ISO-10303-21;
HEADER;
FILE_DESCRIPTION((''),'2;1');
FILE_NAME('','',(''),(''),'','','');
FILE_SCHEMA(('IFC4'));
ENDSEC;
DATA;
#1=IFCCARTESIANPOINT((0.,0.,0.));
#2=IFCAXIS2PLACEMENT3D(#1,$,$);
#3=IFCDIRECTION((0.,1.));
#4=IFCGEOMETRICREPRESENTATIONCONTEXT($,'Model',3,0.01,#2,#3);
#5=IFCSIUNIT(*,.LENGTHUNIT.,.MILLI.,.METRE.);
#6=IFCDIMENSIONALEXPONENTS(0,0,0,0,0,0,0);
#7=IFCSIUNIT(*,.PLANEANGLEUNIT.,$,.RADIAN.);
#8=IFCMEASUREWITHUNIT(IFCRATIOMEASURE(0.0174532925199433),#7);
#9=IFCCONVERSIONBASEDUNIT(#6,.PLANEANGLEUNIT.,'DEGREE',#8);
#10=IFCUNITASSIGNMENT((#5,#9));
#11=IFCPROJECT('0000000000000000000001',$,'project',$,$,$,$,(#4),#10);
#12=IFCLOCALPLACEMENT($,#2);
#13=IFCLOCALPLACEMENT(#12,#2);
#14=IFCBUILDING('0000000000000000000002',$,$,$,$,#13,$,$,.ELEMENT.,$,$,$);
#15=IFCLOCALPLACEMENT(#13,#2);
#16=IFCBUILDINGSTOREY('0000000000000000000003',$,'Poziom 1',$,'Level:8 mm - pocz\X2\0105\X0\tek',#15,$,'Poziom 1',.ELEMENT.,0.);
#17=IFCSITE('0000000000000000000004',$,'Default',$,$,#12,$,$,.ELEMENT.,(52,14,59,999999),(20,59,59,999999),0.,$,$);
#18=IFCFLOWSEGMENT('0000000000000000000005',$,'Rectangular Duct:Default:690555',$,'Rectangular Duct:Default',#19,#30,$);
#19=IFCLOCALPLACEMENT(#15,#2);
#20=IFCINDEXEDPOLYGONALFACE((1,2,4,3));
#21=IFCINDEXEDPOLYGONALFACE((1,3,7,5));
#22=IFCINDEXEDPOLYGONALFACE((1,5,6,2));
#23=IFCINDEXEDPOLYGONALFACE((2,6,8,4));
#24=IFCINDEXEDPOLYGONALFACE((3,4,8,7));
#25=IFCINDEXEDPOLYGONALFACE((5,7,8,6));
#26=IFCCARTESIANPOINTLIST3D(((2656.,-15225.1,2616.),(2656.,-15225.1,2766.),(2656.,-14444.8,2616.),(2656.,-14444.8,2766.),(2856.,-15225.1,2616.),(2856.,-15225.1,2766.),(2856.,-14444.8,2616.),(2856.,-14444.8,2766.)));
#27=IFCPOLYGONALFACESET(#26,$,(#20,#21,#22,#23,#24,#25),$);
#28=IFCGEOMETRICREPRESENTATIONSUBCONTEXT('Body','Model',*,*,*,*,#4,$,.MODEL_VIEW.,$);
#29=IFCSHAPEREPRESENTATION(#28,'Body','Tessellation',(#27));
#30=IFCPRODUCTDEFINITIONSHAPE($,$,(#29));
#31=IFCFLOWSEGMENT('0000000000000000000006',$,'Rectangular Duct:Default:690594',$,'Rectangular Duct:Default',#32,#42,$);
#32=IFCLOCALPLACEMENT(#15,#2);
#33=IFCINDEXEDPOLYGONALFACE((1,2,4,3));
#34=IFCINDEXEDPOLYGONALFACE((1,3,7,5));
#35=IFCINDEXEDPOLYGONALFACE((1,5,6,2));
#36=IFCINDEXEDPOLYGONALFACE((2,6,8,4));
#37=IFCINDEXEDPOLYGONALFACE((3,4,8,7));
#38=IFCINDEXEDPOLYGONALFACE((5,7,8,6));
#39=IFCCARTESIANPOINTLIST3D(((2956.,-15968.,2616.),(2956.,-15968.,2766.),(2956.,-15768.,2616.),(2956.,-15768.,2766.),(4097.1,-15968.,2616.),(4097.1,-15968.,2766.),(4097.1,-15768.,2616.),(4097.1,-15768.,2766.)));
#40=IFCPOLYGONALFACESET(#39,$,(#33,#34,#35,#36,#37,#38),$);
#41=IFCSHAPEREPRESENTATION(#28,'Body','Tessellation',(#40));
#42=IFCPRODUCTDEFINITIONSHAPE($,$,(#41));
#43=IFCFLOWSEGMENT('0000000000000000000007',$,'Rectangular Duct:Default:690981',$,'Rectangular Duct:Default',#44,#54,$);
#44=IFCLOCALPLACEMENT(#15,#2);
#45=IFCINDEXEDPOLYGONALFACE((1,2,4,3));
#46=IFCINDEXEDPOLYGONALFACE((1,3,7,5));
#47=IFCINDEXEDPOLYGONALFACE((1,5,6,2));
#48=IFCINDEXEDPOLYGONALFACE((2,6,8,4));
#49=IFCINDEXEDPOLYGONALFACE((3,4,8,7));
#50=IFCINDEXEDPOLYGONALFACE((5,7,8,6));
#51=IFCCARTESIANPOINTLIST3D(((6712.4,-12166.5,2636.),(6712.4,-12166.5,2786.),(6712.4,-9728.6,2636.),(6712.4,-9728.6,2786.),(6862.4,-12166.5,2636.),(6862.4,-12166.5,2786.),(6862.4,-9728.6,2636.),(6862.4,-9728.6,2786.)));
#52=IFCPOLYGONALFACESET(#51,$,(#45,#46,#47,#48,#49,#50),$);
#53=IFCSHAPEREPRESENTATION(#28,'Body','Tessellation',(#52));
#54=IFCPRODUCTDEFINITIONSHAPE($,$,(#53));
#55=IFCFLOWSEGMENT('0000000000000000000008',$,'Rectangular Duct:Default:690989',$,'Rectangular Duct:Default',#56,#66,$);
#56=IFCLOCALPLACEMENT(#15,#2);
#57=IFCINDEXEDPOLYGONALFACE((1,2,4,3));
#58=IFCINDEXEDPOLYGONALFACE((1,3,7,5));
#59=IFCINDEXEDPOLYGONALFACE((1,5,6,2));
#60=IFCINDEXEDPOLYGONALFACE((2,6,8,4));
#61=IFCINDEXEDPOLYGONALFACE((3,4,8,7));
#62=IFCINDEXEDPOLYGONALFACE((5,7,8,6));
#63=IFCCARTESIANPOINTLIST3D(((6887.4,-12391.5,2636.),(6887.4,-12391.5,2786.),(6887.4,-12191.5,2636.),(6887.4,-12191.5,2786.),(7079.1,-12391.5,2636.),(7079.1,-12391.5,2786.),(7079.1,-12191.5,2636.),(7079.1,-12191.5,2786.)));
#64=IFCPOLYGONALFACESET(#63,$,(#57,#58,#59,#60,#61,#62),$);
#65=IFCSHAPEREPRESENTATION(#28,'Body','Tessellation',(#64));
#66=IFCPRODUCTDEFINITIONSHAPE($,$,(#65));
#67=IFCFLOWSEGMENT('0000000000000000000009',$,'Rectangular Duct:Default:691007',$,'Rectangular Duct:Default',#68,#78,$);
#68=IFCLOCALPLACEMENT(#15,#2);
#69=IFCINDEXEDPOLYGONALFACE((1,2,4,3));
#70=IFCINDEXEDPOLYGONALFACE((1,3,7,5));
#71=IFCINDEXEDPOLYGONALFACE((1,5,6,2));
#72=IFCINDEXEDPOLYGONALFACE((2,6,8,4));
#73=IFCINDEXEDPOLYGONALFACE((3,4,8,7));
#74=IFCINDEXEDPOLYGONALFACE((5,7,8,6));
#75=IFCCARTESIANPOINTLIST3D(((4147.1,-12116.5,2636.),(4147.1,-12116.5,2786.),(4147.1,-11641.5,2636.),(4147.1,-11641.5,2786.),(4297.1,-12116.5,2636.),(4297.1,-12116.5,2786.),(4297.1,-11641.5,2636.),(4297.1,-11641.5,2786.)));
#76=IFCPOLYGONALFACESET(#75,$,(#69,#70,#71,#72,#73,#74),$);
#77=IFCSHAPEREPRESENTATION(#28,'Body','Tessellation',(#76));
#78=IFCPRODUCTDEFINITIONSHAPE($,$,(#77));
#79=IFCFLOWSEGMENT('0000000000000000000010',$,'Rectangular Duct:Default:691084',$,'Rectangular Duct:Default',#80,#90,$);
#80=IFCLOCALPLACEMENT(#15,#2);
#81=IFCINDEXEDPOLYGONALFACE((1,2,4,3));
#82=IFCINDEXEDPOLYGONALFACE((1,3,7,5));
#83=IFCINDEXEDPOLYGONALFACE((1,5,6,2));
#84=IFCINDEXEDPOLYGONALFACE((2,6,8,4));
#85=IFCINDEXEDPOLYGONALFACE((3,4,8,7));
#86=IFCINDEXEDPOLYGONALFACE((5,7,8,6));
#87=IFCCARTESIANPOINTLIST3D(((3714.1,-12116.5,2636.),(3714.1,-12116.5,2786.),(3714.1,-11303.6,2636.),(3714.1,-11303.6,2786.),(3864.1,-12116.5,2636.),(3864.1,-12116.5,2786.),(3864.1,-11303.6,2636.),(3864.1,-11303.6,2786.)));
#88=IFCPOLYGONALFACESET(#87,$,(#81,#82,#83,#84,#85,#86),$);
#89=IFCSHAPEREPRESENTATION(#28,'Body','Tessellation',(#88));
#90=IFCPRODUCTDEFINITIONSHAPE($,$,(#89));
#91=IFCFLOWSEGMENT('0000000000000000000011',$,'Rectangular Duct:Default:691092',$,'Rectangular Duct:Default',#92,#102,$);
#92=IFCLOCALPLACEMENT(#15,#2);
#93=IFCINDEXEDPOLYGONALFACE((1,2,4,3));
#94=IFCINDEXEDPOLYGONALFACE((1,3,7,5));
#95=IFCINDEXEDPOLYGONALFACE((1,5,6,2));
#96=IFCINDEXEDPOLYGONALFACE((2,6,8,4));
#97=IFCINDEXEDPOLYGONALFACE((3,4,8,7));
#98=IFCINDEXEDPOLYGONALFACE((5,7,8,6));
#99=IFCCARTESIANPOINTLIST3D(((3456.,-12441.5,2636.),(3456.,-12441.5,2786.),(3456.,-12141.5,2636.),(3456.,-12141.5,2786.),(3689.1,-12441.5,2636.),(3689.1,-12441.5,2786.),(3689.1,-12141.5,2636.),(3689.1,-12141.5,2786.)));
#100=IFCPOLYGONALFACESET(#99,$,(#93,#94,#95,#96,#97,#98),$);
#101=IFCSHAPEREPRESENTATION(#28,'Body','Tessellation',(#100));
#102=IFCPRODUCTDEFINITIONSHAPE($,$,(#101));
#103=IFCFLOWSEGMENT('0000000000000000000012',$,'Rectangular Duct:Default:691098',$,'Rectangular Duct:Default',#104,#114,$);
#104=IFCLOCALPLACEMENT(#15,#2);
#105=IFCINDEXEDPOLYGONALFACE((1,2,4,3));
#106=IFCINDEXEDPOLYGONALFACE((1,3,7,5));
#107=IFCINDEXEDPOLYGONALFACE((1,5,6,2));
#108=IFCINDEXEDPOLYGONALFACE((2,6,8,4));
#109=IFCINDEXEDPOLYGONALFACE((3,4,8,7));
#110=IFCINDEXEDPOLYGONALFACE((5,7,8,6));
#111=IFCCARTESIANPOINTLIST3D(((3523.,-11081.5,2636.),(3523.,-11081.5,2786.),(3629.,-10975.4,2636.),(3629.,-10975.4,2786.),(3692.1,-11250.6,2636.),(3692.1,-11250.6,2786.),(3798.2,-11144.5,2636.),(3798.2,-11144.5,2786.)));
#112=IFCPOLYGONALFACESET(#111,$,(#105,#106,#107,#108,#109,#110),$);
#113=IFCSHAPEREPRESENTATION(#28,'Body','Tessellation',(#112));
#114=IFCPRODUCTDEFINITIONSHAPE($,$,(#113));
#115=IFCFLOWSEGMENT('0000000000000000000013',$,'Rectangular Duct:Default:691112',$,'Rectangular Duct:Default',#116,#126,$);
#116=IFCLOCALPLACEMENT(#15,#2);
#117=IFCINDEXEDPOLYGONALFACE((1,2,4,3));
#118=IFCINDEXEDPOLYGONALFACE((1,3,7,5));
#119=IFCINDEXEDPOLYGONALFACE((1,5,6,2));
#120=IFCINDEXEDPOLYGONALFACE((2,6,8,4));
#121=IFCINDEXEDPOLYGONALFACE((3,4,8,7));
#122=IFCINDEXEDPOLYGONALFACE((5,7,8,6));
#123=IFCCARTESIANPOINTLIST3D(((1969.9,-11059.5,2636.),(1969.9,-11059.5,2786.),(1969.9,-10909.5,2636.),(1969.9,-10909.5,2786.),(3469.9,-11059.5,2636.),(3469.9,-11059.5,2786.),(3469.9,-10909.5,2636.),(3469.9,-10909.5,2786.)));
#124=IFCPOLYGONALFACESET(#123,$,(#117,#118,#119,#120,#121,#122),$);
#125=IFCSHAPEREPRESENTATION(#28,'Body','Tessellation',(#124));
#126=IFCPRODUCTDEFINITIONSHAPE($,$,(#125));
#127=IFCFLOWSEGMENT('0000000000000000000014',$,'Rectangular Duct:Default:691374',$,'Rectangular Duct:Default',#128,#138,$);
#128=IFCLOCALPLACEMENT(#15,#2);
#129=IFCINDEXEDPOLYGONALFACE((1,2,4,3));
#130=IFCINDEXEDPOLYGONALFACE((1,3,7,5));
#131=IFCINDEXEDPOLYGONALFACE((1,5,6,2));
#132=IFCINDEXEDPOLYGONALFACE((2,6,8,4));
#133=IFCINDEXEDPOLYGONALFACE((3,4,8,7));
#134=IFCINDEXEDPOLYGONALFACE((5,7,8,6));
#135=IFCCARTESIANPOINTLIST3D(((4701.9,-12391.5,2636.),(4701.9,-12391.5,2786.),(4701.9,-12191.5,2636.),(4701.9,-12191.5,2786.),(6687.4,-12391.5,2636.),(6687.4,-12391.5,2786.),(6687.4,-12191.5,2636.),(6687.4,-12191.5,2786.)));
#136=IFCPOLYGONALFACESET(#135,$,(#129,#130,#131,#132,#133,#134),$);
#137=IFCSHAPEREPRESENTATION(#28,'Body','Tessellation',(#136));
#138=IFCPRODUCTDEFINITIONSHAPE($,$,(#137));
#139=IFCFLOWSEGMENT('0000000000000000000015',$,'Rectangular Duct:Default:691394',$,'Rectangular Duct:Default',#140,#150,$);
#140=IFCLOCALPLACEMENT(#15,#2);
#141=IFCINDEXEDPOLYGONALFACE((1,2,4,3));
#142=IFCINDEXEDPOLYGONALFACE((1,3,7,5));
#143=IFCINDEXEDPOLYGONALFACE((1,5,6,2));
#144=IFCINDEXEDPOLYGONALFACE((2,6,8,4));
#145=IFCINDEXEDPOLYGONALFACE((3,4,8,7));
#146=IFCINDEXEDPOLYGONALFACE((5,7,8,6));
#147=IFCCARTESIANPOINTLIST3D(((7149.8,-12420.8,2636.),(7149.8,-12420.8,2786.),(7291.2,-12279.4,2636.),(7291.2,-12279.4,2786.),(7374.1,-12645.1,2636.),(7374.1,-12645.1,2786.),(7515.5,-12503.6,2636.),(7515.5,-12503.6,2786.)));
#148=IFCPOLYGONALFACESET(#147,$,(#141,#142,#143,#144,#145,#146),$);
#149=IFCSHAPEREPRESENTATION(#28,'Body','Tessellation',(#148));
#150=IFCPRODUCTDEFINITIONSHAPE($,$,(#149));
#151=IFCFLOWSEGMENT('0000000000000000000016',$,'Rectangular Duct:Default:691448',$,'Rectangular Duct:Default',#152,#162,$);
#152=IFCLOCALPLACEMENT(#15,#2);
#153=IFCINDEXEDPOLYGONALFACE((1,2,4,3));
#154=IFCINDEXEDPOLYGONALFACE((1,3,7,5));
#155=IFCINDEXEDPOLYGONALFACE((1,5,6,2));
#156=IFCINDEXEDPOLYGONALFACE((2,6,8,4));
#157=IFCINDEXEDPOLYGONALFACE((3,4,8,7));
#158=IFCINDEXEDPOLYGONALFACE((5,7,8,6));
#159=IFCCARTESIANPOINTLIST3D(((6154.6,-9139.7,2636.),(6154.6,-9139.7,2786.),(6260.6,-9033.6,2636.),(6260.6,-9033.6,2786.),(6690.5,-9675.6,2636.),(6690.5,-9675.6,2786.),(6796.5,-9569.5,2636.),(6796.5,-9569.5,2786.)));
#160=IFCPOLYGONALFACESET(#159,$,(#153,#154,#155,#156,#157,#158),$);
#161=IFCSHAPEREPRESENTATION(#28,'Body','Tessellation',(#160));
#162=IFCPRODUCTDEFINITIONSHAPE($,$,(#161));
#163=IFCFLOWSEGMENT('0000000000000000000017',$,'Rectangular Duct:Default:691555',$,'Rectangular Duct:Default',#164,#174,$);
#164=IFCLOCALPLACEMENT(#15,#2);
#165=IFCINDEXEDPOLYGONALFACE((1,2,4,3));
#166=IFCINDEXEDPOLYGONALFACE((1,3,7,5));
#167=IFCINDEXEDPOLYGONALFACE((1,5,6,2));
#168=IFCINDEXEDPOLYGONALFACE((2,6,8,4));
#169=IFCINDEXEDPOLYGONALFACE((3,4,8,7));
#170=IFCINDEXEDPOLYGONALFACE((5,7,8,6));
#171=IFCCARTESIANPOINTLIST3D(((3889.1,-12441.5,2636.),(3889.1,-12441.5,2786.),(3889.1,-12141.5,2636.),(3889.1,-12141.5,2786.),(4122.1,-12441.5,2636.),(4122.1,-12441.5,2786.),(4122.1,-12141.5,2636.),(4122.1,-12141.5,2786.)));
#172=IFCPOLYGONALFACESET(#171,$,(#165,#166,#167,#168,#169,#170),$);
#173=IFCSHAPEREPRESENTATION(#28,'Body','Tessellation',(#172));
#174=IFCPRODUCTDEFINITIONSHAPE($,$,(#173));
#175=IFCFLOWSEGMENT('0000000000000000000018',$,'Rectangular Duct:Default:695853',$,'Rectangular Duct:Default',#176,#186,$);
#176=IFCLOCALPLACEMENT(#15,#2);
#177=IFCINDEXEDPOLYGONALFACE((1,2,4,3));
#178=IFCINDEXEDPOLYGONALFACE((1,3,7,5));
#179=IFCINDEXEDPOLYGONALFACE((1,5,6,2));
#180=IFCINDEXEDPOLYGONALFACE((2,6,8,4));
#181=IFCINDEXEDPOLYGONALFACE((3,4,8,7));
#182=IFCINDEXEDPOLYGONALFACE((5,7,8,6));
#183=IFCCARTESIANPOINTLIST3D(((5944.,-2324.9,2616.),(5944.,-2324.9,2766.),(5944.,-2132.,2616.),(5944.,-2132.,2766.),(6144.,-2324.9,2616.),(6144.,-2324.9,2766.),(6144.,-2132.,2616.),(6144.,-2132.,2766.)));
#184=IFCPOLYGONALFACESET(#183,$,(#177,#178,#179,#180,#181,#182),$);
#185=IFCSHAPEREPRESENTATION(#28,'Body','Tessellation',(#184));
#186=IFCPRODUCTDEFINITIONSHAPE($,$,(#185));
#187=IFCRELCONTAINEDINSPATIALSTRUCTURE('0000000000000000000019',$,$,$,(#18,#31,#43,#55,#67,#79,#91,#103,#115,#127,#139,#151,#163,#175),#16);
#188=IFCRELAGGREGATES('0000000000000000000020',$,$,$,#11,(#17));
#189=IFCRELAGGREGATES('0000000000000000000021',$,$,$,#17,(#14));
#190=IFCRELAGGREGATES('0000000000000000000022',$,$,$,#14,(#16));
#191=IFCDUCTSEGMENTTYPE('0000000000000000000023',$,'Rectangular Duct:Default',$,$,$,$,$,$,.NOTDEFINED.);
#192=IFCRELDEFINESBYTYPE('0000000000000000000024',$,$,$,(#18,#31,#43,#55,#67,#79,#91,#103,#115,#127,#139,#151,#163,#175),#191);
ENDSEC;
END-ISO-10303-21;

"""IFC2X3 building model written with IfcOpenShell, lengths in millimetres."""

from ifc_helpers import new_model, entity, si_unit, converted_unit, direction, frame, frame_2d, origin, origin_2d_with_axis, place, context, subcontext, project, spatial, rectangle, extrude, type_object, element, save


model = new_model("IFC2X3")

# Units and contexts
model_context = context("Model", 3, precision=0.01, world=origin(), true_north=direction((0.0, 1.0)))
body_context = subcontext(model_context, "Body", "Model", "MODEL_VIEW")
ifc_project = project(units=[si_unit("LENGTHUNIT", "METRE", prefix="MILLI"), converted_unit("PLANEANGLEUNIT", "DEGREE", entity("IfcRatioMeasure", 0.0174532925199433), si_unit("PLANEANGLEUNIT", "RADIAN"), dimensions=[0, 0, 0, 0, 0, 0, 0])], contexts=[model_context])

# Site, building, storey
site_placement = place(None, origin())
site = spatial("IfcSite", under=ifc_project, at=site_placement, Name="Default", CompositionType="ELEMENT", RefLatitude=(52, 14, 59, 999999), RefLongitude=(20, 59, 59, 999999), RefElevation=0.0)
building_placement = place(site_placement, origin())
building = spatial("IfcBuilding", under=site, at=building_placement, CompositionType="ELEMENT")
storey_placement = place(building_placement, origin())
storey = spatial("IfcBuildingStorey", under=building, at=storey_placement, Name="Poziom 1", ObjectType="Level:8 mm - początek", LongName="Poziom 1", CompositionType="ELEMENT", Elevation=0.0)

# Flow segments
duct_segment_type_1 = type_object("IfcDuctSegmentType", Name="Rectangular Duct:Default", PredefinedType="NOTDEFINED")
flow_segment_1_placement = place(storey_placement, origin())
element("IfcFlowSegment", 1, at=flow_segment_1_placement, inside=storey, type_object=duct_segment_type_1, Name="Rectangular Duct:Default:690555", ObjectType="Rectangular Duct:Default", context=body_context, shape_type="SweptSolid", body=[
    extrude(rectangle(XDim=780.4, YDim=200.0, at=frame_2d((0.0, 0.0), x_axis=(1.0, 0.0))), frame((2756.0, -14835.0, 2616.0), z_axis=(0.0, 0.0, 1.0), x_axis=(0.0, -1.0, 0.0)), (0.0, 0.0, 1.0), 150.0),
])
flow_segment_2_placement = place(storey_placement, origin())
element("IfcFlowSegment", 2, at=flow_segment_2_placement, inside=storey, type_object=duct_segment_type_1, Name="Rectangular Duct:Default:690594", ObjectType="Rectangular Duct:Default", context=body_context, shape_type="SweptSolid", body=[
    extrude(rectangle(XDim=1141.1, YDim=200.0, at=frame_2d((0.0, 0.0), x_axis=(1.0, 0.0))), frame((3526.6, -15868.0, 2616.0)), (0.0, 0.0, 1.0), 150.0),
])
flow_segment_3_placement = place(storey_placement, origin())
element("IfcFlowSegment", 3, at=flow_segment_3_placement, inside=storey, type_object=duct_segment_type_1, Name="Rectangular Duct:Default:690981", ObjectType="Rectangular Duct:Default", context=body_context, shape_type="SweptSolid", body=[
    extrude(rectangle(XDim=2437.9, YDim=150.0, at=origin_2d_with_axis()), frame((6787.4, -10947.6, 2636.0), z_axis=(0.0, 0.0, 1.0), x_axis=(0.0, 1.0, 0.0)), (0.0, 0.0, 1.0), 150.0),
])
flow_segment_4_placement = place(storey_placement, origin())
element("IfcFlowSegment", 4, at=flow_segment_4_placement, inside=storey, type_object=duct_segment_type_1, Name="Rectangular Duct:Default:690989", ObjectType="Rectangular Duct:Default", context=body_context, shape_type="SweptSolid", body=[
    extrude(rectangle(XDim=191.7, YDim=200.0, at=frame_2d((0.0, 0.0), x_axis=(1.0, 0.0))), frame((6983.3, -12291.5, 2636.0)), (0.0, 0.0, 1.0), 150.0),
])
flow_segment_5_placement = place(storey_placement, origin())
element("IfcFlowSegment", 5, at=flow_segment_5_placement, inside=storey, type_object=duct_segment_type_1, Name="Rectangular Duct:Default:691007", ObjectType="Rectangular Duct:Default", context=body_context, shape_type="SweptSolid", body=[
    extrude(rectangle(XDim=475.0, YDim=150.0, at=frame_2d((0.0, 0.0), x_axis=(1.0, 0.0))), frame((4222.1, -11879.0, 2636.0), z_axis=(0.0, 0.0, 1.0), x_axis=(0.0, -1.0, 0.0)), (0.0, 0.0, 1.0), 150.0),
])
flow_segment_6_placement = place(storey_placement, origin())
element("IfcFlowSegment", 6, at=flow_segment_6_placement, inside=storey, type_object=duct_segment_type_1, Name="Rectangular Duct:Default:691084", ObjectType="Rectangular Duct:Default", context=body_context, shape_type="SweptSolid", body=[
    extrude(rectangle(XDim=812.9, YDim=150.0, at=frame_2d((0.0, 0.0), x_axis=(1.0, 0.0))), frame((3789.1, -11710.1, 2636.0), z_axis=(0.0, 0.0, 1.0), x_axis=(0.0, 1.0, 0.0)), (0.0, 0.0, 1.0), 150.0),
])
flow_segment_7_placement = place(storey_placement, origin())
element("IfcFlowSegment", 7, at=flow_segment_7_placement, inside=storey, type_object=duct_segment_type_1, Name="Rectangular Duct:Default:691092", ObjectType="Rectangular Duct:Default", context=body_context, shape_type="SweptSolid", body=[
    extrude(rectangle(XDim=233.1, YDim=300.0, at=frame_2d((0.0, 0.0), x_axis=(1.0, 0.0))), frame((3572.5, -12291.5, 2636.0)), (0.0, 0.0, 1.0), 150.0),
])
flow_segment_8_placement = place(storey_placement, origin())
element("IfcFlowSegment", 8, at=flow_segment_8_placement, inside=storey, type_object=duct_segment_type_1, Name="Rectangular Duct:Default:691098", ObjectType="Rectangular Duct:Default", context=body_context, shape_type="SweptSolid", body=[
    extrude(rectangle(XDim=239.2, YDim=150.0, at=origin_2d_with_axis()), frame((3660.6, -11113.0, 2636.0), z_axis=(0.0, 0.0, 1.0), x_axis=(-0.707107, 0.707107, 0.0)), (0.0, 0.0, 1.0), 150.0),
])
flow_segment_9_placement = place(storey_placement, origin())
element("IfcFlowSegment", 9, at=flow_segment_9_placement, inside=storey, type_object=duct_segment_type_1, Name="Rectangular Duct:Default:691112", ObjectType="Rectangular Duct:Default", context=body_context, shape_type="SweptSolid", body=[
    extrude(rectangle(XDim=1500.0, YDim=150.0, at=frame_2d((0.0, 0.0), x_axis=(1.0, 0.0))), frame((2719.9, -10984.5, 2636.0), z_axis=(0.0, 0.0, 1.0), x_axis=(-1.0, 0.0, 0.0)), (0.0, 0.0, 1.0), 150.0),
])
flow_segment_10_placement = place(storey_placement, origin())
element("IfcFlowSegment", 10, at=flow_segment_10_placement, inside=storey, type_object=duct_segment_type_1, Name="Rectangular Duct:Default:691374", ObjectType="Rectangular Duct:Default", context=body_context, shape_type="SweptSolid", body=[
    extrude(rectangle(XDim=1985.5, YDim=200.0, at=frame_2d((0.0, 0.0), x_axis=(1.0, 0.0))), frame((5694.7, -12291.5, 2636.0), z_axis=(0.0, 0.0, 1.0), x_axis=(-1.0, 0.0, 0.0)), (0.0, 0.0, 1.0), 150.0),
])
flow_segment_11_placement = place(storey_placement, origin())
element("IfcFlowSegment", 11, at=flow_segment_11_placement, inside=storey, type_object=duct_segment_type_1, Name="Rectangular Duct:Default:691394", ObjectType="Rectangular Duct:Default", context=body_context, shape_type="SweptSolid", body=[
    extrude(rectangle(XDim=317.2, YDim=200.0, at=frame_2d((0.0, 0.0), x_axis=(1.0, 0.0))), frame((7332.6, -12462.2, 2636.0), z_axis=(0.0, 0.0, 1.0), x_axis=(0.707107, -0.707107, 0.0)), (0.0, 0.0, 1.0), 150.0),
])
flow_segment_12_placement = place(storey_placement, origin())
element("IfcFlowSegment", 12, at=flow_segment_12_placement, inside=storey, type_object=duct_segment_type_1, Name="Rectangular Duct:Default:691448", ObjectType="Rectangular Duct:Default", context=body_context, shape_type="SweptSolid", body=[
    extrude(rectangle(XDim=757.9, YDim=150.0, at=frame_2d((0.0, 0.0), x_axis=(1.0, 0.0))), frame((6475.6, -9354.6, 2636.0), z_axis=(0.0, 0.0, 1.0), x_axis=(-0.707107, 0.707107, 0.0)), (0.0, 0.0, 1.0), 150.0),
])
flow_segment_13_placement = place(storey_placement, origin())
element("IfcFlowSegment", 13, at=flow_segment_13_placement, inside=storey, type_object=duct_segment_type_1, Name="Rectangular Duct:Default:691555", ObjectType="Rectangular Duct:Default", context=body_context, shape_type="SweptSolid", body=[
    extrude(rectangle(XDim=233.1, YDim=300.0, at=frame_2d((0.0, 0.0), x_axis=(1.0, 0.0))), frame((4005.6, -12291.5, 2636.0)), (0.0, 0.0, 1.0), 150.0),
])
flow_segment_14_placement = place(storey_placement, origin())
element("IfcFlowSegment", 14, at=flow_segment_14_placement, inside=storey, type_object=duct_segment_type_1, Name="Rectangular Duct:Default:695853", ObjectType="Rectangular Duct:Default", context=body_context, shape_type="SweptSolid", body=[
    extrude(rectangle(XDim=192.9, YDim=200.0, at=origin_2d_with_axis()), frame((6044.0, -2228.4, 2616.0), z_axis=(0.0, 0.0, 1.0), x_axis=(0.0, 1.0, 0.0)), (0.0, 0.0, 1.0), 150.0),
])

save(model, "model.ifc")
